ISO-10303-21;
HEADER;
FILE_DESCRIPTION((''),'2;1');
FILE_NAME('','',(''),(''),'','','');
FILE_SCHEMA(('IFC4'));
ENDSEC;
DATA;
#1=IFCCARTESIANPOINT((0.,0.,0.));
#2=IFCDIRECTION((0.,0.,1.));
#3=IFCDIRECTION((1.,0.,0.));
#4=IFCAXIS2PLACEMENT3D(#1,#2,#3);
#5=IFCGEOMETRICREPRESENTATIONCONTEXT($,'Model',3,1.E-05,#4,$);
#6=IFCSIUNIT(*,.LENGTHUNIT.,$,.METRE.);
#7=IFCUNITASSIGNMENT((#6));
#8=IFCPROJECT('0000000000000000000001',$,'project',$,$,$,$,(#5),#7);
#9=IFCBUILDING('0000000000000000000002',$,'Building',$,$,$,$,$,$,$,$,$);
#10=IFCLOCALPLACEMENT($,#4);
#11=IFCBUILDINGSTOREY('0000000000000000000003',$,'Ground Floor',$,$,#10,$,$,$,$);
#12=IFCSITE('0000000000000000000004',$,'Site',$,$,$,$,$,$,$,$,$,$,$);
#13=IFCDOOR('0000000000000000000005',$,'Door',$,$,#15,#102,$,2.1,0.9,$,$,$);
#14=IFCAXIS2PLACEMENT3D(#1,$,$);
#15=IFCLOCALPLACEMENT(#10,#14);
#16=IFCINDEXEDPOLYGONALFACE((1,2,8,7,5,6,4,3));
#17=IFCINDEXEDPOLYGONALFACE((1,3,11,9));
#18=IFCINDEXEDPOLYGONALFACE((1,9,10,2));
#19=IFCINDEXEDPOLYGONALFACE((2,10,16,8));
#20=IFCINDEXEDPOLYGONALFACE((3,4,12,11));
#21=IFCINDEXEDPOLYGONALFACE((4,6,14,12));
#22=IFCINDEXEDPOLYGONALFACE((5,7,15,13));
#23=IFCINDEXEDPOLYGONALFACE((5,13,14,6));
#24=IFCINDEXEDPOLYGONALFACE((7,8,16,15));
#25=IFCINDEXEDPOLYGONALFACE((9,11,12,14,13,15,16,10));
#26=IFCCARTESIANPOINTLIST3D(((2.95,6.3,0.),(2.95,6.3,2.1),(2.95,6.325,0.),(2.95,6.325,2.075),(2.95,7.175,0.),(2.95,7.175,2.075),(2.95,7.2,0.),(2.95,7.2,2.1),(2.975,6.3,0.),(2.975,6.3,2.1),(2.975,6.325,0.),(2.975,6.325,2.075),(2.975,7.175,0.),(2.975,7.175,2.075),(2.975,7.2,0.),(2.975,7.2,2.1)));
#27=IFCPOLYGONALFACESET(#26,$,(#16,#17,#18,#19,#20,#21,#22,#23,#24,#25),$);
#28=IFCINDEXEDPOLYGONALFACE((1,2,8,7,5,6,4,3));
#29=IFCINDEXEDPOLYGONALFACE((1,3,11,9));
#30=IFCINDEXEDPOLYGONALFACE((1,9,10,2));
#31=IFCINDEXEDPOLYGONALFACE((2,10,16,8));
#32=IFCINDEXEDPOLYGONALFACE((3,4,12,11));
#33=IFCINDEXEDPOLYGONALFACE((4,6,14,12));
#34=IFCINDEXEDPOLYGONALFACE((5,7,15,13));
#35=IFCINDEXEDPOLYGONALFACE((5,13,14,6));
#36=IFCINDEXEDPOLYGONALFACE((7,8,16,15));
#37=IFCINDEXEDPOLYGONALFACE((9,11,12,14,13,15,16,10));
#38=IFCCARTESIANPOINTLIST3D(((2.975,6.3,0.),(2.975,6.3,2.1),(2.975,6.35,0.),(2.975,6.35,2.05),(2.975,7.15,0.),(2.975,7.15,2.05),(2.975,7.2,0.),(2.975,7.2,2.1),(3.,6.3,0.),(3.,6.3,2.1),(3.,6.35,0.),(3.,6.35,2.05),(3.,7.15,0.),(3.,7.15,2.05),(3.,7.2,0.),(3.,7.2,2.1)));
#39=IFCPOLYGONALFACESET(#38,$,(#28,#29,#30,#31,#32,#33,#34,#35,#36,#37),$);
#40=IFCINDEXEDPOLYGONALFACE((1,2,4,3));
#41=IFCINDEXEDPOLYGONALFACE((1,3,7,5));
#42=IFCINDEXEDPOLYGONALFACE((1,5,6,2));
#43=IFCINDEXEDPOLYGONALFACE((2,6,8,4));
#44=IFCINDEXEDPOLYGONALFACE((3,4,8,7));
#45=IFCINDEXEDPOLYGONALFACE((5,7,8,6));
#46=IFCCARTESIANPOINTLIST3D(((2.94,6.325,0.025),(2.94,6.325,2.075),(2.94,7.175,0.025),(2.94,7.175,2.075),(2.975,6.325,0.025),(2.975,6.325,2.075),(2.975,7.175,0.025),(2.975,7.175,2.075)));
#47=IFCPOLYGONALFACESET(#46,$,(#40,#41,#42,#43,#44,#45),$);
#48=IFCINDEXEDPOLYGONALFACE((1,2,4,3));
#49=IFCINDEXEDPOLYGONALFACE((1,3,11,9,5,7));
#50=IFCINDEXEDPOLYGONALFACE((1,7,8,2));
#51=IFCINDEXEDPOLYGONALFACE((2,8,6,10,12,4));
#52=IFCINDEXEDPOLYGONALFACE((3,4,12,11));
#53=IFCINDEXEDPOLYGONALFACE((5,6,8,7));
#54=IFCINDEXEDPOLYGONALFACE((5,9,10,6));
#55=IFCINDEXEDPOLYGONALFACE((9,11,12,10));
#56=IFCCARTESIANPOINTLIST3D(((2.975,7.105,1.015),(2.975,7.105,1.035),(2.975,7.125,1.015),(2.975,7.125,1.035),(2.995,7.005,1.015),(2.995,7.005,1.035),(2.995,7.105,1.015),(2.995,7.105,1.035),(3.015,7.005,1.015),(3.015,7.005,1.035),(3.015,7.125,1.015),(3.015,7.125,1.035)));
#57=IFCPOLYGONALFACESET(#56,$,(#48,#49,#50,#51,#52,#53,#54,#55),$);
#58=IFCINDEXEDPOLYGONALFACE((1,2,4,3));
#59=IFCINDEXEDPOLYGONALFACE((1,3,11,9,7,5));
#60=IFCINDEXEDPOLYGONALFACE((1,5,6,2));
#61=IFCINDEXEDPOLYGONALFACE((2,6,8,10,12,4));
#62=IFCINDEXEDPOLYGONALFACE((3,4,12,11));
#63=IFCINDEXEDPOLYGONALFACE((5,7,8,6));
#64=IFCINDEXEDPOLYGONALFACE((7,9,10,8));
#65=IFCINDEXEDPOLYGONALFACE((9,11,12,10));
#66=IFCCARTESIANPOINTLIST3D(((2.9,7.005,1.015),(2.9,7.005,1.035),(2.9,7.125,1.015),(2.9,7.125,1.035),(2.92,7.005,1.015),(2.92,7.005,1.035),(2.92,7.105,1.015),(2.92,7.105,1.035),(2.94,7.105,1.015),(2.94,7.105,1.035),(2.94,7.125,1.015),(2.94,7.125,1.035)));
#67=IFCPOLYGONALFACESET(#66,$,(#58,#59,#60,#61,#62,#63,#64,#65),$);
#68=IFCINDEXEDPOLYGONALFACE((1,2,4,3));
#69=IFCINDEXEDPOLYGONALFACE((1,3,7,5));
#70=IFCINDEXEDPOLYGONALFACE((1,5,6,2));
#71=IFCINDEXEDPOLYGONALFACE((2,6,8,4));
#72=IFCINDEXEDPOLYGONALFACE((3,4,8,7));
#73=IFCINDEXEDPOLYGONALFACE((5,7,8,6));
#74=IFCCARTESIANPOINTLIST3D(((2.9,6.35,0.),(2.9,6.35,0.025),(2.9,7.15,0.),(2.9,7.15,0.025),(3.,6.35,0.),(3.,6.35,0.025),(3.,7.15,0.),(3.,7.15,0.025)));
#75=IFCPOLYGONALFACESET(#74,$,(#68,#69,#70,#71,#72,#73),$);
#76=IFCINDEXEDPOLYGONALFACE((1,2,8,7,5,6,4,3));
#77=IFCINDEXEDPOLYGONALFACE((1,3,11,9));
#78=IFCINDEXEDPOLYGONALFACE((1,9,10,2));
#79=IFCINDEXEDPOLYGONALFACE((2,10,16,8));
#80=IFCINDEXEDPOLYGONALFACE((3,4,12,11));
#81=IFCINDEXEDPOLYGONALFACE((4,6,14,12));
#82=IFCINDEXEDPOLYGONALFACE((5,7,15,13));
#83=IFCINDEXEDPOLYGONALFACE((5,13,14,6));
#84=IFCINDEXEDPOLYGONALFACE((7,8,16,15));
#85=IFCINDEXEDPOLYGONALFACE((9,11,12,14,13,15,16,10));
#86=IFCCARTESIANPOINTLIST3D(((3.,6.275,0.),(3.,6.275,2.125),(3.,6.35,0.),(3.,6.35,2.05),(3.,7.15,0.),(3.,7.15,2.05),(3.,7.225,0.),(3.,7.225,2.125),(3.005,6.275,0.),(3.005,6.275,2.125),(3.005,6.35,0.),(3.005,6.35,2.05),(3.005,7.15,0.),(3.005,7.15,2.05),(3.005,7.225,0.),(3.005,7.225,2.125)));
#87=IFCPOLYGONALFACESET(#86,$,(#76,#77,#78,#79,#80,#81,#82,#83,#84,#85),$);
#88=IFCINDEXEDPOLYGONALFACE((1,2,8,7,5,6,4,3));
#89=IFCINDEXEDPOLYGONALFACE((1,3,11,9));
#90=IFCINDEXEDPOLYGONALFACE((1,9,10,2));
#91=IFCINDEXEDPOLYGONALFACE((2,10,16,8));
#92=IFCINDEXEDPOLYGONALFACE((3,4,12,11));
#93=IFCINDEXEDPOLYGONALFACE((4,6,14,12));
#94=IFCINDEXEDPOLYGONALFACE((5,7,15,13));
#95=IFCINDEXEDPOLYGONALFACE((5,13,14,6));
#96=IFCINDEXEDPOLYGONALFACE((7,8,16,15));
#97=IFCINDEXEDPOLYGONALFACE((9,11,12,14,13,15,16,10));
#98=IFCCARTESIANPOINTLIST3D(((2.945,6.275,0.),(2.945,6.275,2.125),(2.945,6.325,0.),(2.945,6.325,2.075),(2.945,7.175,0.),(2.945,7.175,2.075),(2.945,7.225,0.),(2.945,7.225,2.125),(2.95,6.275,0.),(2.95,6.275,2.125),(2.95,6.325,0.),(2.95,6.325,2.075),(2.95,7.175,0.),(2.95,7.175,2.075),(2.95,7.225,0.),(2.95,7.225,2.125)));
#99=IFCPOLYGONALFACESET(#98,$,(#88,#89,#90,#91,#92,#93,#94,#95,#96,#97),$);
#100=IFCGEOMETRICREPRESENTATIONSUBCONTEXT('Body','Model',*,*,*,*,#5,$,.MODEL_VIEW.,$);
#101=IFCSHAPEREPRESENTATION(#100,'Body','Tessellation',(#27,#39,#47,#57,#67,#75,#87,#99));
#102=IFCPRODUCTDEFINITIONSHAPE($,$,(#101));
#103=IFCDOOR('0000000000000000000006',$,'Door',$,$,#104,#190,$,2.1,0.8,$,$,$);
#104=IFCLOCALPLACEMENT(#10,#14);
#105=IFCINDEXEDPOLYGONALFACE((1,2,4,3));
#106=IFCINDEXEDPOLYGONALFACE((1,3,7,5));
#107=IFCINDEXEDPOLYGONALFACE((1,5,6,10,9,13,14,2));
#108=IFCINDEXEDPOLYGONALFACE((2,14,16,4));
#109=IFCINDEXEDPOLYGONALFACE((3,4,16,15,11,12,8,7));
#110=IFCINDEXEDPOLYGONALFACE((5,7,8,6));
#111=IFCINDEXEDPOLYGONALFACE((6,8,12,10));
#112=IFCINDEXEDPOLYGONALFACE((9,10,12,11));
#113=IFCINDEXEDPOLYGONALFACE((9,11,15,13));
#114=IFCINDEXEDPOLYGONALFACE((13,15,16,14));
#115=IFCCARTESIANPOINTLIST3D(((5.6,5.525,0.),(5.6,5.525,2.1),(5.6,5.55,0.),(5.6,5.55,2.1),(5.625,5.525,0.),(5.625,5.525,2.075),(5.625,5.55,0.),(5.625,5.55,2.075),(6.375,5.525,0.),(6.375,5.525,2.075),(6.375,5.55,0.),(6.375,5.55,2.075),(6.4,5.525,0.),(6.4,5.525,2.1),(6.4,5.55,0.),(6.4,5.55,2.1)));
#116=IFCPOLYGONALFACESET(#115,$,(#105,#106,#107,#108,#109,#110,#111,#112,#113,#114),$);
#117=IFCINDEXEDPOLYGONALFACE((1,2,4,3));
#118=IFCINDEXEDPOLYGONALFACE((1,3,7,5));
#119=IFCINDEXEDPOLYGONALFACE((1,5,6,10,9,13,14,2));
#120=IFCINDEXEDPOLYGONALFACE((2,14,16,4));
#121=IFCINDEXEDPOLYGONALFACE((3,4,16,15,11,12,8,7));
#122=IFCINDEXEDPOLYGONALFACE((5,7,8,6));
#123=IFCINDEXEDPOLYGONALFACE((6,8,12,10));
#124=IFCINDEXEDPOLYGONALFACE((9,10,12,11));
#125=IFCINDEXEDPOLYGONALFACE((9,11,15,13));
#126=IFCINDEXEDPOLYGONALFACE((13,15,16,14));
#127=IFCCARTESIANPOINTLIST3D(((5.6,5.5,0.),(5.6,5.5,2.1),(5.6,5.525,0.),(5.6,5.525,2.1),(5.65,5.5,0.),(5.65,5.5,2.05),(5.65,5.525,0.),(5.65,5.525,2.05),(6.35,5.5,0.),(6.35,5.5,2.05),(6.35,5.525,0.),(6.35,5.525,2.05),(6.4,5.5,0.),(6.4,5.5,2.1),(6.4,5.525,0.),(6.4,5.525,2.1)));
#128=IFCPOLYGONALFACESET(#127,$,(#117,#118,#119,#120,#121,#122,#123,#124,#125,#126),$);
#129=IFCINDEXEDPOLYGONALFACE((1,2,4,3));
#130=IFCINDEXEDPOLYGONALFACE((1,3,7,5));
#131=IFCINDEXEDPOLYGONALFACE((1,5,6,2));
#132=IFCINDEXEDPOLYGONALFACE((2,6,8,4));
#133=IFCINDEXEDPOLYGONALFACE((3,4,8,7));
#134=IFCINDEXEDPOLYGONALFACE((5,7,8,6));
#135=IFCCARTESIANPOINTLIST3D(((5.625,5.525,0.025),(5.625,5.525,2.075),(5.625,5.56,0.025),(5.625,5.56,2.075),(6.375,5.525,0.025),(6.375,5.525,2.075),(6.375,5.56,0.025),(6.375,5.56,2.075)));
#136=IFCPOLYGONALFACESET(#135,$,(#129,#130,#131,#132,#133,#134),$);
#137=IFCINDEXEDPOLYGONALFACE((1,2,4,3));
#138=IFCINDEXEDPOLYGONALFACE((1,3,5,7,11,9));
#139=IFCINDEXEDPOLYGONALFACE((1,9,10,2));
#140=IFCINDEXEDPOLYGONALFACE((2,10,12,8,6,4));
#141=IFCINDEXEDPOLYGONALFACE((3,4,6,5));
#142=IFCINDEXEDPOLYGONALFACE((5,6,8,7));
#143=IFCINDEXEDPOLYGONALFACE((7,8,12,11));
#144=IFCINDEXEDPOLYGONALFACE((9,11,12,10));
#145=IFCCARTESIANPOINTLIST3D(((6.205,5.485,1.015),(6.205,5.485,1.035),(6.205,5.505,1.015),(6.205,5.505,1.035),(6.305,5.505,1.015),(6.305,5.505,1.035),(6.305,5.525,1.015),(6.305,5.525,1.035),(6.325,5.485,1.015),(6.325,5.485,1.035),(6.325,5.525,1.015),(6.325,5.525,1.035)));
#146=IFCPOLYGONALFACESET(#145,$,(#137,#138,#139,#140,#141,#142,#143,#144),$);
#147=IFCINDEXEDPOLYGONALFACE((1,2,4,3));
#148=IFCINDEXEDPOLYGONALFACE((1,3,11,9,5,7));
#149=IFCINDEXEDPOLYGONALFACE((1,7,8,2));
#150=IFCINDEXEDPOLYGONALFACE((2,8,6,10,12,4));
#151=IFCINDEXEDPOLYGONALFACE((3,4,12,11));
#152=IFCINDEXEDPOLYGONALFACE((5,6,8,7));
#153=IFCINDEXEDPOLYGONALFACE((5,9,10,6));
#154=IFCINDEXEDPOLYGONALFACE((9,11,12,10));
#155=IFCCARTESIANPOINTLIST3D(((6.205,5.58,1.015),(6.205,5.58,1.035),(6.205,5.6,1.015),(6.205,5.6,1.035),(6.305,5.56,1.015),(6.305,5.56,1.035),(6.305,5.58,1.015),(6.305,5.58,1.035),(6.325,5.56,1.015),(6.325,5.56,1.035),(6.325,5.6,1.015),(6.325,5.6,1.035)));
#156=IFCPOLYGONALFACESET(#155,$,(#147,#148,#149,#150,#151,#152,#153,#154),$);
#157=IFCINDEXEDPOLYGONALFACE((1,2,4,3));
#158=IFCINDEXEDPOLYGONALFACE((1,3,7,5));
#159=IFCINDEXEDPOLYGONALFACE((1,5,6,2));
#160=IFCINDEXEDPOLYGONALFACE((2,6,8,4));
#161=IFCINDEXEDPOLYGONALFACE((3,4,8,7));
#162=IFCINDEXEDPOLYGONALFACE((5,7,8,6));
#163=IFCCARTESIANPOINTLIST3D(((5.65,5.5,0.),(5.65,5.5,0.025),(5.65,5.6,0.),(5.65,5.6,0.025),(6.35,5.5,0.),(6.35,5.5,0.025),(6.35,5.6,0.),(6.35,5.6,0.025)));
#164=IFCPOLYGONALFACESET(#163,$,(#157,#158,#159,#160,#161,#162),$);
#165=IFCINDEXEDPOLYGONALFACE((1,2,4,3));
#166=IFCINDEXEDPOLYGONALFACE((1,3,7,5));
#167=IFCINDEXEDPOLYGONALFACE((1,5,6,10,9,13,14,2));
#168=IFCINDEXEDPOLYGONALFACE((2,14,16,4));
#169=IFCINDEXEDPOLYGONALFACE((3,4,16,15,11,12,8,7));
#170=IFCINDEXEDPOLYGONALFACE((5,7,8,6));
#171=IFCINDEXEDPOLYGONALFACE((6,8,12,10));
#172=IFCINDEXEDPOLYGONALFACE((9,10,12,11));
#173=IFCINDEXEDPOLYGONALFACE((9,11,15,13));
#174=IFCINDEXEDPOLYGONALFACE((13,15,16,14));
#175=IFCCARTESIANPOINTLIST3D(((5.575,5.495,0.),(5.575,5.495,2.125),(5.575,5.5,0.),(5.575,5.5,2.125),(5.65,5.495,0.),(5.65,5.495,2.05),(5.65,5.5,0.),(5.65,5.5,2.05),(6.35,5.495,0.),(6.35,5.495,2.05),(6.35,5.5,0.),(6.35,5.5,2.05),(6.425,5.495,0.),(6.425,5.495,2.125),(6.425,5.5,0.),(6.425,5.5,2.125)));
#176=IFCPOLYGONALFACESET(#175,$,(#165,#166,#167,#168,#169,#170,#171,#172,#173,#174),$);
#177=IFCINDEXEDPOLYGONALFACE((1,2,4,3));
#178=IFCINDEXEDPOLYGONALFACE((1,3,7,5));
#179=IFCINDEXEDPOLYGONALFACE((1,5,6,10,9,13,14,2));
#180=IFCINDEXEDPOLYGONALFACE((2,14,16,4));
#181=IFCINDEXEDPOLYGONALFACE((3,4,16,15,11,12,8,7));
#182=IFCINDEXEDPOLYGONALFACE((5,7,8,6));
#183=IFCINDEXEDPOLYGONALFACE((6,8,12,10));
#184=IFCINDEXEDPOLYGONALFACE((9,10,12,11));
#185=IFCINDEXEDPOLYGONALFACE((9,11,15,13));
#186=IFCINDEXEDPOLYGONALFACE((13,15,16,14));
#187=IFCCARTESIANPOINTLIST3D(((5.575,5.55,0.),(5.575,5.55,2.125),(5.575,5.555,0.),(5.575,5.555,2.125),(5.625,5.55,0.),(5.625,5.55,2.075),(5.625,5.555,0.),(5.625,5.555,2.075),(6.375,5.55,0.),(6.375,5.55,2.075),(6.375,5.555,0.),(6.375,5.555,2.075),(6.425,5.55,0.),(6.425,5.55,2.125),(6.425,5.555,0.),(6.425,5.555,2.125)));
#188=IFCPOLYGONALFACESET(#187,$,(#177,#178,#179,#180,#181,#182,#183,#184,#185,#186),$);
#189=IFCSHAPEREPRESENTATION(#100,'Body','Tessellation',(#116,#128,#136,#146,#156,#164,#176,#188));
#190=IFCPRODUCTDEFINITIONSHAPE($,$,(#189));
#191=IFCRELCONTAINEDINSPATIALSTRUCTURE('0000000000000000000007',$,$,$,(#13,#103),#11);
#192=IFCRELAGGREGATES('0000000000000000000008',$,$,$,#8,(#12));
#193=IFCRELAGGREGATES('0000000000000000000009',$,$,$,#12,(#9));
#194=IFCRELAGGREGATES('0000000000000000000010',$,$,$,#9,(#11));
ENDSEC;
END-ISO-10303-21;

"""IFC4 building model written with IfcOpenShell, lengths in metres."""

from ifc_helpers import new_model, si_unit, frame, origin_with_axes, place, context, subcontext, project, spatial, line, indexed_curve, outline, extrude, element, save


model = new_model("IFC4")

# Units and contexts
model_context = context("Model", 3, precision=1e-05, world=origin_with_axes())
body_context = subcontext(model_context, "Body", "Model", "MODEL_VIEW")
ifc_project = project(units=[si_unit("LENGTHUNIT", "METRE")], contexts=[model_context])

# Site, building, storey
site = spatial("IfcSite", under=ifc_project, Name="Site")
building = spatial("IfcBuilding", under=site, Name="Building")
storey_placement = place(None, origin_with_axes())
storey = spatial("IfcBuildingStorey", under=building, at=storey_placement, Name="Ground Floor")

# Doors
door_1_placement = place(storey_placement, frame((3.0, 6.3, 0.0), z_axis=(0.0, 0.0, 1.0), x_axis=(0.0, 1.0, 0.0)))
element("IfcDoor", 1, at=door_1_placement, inside=storey, Name="Door", OverallHeight=2.1, OverallWidth=0.9, context=body_context, shape_type="SweptSolid", body=[
    extrude(outline(indexed_curve([(0.0, 0.0), (0.0, 2.1), (0.9, 2.1), (0.9, 0.0), (0.875, 0.0), (0.875, 2.075), (0.025, 2.075), (0.025, 0.0)], segments=[line(1, 2, 3, 4, 5, 6, 7, 8, 1)])), frame((0.0, 0.025, 0.0), z_axis=(0.0, -1.0, 0.0), x_axis=(1.0, 0.0, 0.0)), (0.0, 0.0, -1.0), 0.025),
    extrude(outline(indexed_curve([(0.0, 0.0), (0.0, 2.1), (0.9, 2.1), (0.9, 0.0), (0.85, 0.0), (0.85, 2.05), (0.05, 2.05), (0.05, 0.0)], segments=[line(1, 2, 3, 4, 5, 6, 7, 8, 1)])), frame((0.0, 0.0, 0.0), z_axis=(0.0, -1.0, 0.0), x_axis=(1.0, 0.0, 0.0)), (0.0, 0.0, -1.0), 0.025),
    extrude(outline(indexed_curve([(0.0, 0.0), (0.85, 0.0), (0.85, 0.035), (0.0, 0.035)], segments=[line(1, 2, 3, 4, 1)])), frame((0.025, 0.025, 0.025), z_axis=(0.0, 0.0, 1.0), x_axis=(1.0, 0.0, 0.0)), (0.0, 0.0, 1.0), 2.05),
    extrude(outline(indexed_curve([(0.0, 0.0), (0.0, -0.04), (-0.12, -0.04), (-0.12, -0.02), (-0.02, -0.02), (-0.02, 0.0)], segments=[line(1, 2, 3, 4, 5, 6, 1)])), frame((0.825, 0.025, 1.015), z_axis=(0.0, 0.0, 1.0), x_axis=(1.0, 0.0, 0.0)), (0.0, 0.0, 1.0), 0.02),
    extrude(outline(indexed_curve([(0.0, 0.0), (0.0, 0.04), (-0.12, 0.04), (-0.12, 0.02), (-0.02, 0.02), (-0.02, 0.0)], segments=[line(1, 2, 3, 4, 5, 6, 1)])), frame((0.825, 0.06, 1.015), z_axis=(0.0, 0.0, 1.0), x_axis=(1.0, 0.0, 0.0)), (0.0, 0.0, 1.0), 0.02),
    extrude(outline(indexed_curve([(0.0, 0.0), (0.8, 0.0), (0.8, 0.1), (0.0, 0.1)], segments=[line(1, 2, 3, 4, 1)])), frame((0.05, 0.0, 0.0), z_axis=(0.0, 0.0, 1.0), x_axis=(1.0, 0.0, 0.0)), (0.0, 0.0, 1.0), 0.025),
    extrude(outline(indexed_curve([(0.0, 0.0), (0.0, 2.125), (0.95, 2.125), (0.95, 0.0), (0.875, 0.0), (0.875, 2.05), (0.075, 2.05), (0.075, 0.0)], segments=[line(1, 2, 3, 4, 5, 6, 7, 8, 1)])), frame((-0.025, -0.005, 0.0), z_axis=(0.0, -1.0, 0.0), x_axis=(1.0, 0.0, 0.0)), (0.0, 0.0, -1.0), 0.005),
    extrude(outline(indexed_curve([(0.0, 0.0), (0.0, 2.125), (0.95, 2.125), (0.95, 0.0), (0.9, 0.0), (0.9, 2.075), (0.05, 2.075), (0.05, 0.0)], segments=[line(1, 2, 3, 4, 5, 6, 7, 8, 1)])), frame((-0.025, 0.05, 0.0), z_axis=(0.0, -1.0, 0.0), x_axis=(1.0, 0.0, 0.0)), (0.0, 0.0, -1.0), 0.005),
])
door_2_placement = place(storey_placement, frame((5.6, 5.5, 0.0), z_axis=(0.0, 0.0, 1.0), x_axis=(1.0, 0.0, 0.0)))
element("IfcDoor", 2, at=door_2_placement, inside=storey, Name="Door", OverallHeight=2.1, OverallWidth=0.8, context=body_context, shape_type="SweptSolid", body=[
    extrude(outline(indexed_curve([(0.0, 0.0), (0.0, 2.1), (0.8, 2.1), (0.8, 0.0), (0.775, 0.0), (0.775, 2.075), (0.025, 2.075), (0.025, 0.0)], segments=[line(1, 2, 3, 4, 5, 6, 7, 8, 1)])), frame((0.0, 0.025, 0.0), z_axis=(0.0, -1.0, 0.0), x_axis=(1.0, 0.0, 0.0)), (0.0, 0.0, -1.0), 0.025),
    extrude(outline(indexed_curve([(0.0, 0.0), (0.0, 2.1), (0.8, 2.1), (0.8, 0.0), (0.75, 0.0), (0.75, 2.05), (0.05, 2.05), (0.05, 0.0)], segments=[line(1, 2, 3, 4, 5, 6, 7, 8, 1)])), frame((0.0, 0.0, 0.0), z_axis=(0.0, -1.0, 0.0), x_axis=(1.0, 0.0, 0.0)), (0.0, 0.0, -1.0), 0.025),
    extrude(outline(indexed_curve([(0.0, 0.0), (0.75, 0.0), (0.75, 0.035), (0.0, 0.035)], segments=[line(1, 2, 3, 4, 1)])), frame((0.025, 0.025, 0.025), z_axis=(0.0, 0.0, 1.0), x_axis=(1.0, 0.0, 0.0)), (0.0, 0.0, 1.0), 2.05),
    extrude(outline(indexed_curve([(0.0, 0.0), (0.0, -0.04), (-0.12, -0.04), (-0.12, -0.02), (-0.02, -0.02), (-0.02, 0.0)], segments=[line(1, 2, 3, 4, 5, 6, 1)])), frame((0.725, 0.025, 1.015), z_axis=(0.0, 0.0, 1.0), x_axis=(1.0, 0.0, 0.0)), (0.0, 0.0, 1.0), 0.02),
    extrude(outline(indexed_curve([(0.0, 0.0), (0.0, 0.04), (-0.12, 0.04), (-0.12, 0.02), (-0.02, 0.02), (-0.02, 0.0)], segments=[line(1, 2, 3, 4, 5, 6, 1)])), frame((0.725, 0.06, 1.015), z_axis=(0.0, 0.0, 1.0), x_axis=(1.0, 0.0, 0.0)), (0.0, 0.0, 1.0), 0.02),
    extrude(outline(indexed_curve([(0.0, 0.0), (0.7, 0.0), (0.7, 0.1), (0.0, 0.1)], segments=[line(1, 2, 3, 4, 1)])), frame((0.05, 0.0, 0.0), z_axis=(0.0, 0.0, 1.0), x_axis=(1.0, 0.0, 0.0)), (0.0, 0.0, 1.0), 0.025),
    extrude(outline(indexed_curve([(0.0, 0.0), (0.0, 2.125), (0.85, 2.125), (0.85, 0.0), (0.775, 0.0), (0.775, 2.05), (0.075, 2.05), (0.075, 0.0)], segments=[line(1, 2, 3, 4, 5, 6, 7, 8, 1)])), frame((-0.025, -0.005, 0.0), z_axis=(0.0, -1.0, 0.0), x_axis=(1.0, 0.0, 0.0)), (0.0, 0.0, -1.0), 0.005),
    extrude(outline(indexed_curve([(0.0, 0.0), (0.0, 2.125), (0.85, 2.125), (0.85, 0.0), (0.8, 0.0), (0.8, 2.075), (0.05, 2.075), (0.05, 0.0)], segments=[line(1, 2, 3, 4, 5, 6, 7, 8, 1)])), frame((-0.025, 0.05, 0.0), z_axis=(0.0, -1.0, 0.0), x_axis=(1.0, 0.0, 0.0)), (0.0, 0.0, -1.0), 0.005),
])

save(model, "model.ifc")
